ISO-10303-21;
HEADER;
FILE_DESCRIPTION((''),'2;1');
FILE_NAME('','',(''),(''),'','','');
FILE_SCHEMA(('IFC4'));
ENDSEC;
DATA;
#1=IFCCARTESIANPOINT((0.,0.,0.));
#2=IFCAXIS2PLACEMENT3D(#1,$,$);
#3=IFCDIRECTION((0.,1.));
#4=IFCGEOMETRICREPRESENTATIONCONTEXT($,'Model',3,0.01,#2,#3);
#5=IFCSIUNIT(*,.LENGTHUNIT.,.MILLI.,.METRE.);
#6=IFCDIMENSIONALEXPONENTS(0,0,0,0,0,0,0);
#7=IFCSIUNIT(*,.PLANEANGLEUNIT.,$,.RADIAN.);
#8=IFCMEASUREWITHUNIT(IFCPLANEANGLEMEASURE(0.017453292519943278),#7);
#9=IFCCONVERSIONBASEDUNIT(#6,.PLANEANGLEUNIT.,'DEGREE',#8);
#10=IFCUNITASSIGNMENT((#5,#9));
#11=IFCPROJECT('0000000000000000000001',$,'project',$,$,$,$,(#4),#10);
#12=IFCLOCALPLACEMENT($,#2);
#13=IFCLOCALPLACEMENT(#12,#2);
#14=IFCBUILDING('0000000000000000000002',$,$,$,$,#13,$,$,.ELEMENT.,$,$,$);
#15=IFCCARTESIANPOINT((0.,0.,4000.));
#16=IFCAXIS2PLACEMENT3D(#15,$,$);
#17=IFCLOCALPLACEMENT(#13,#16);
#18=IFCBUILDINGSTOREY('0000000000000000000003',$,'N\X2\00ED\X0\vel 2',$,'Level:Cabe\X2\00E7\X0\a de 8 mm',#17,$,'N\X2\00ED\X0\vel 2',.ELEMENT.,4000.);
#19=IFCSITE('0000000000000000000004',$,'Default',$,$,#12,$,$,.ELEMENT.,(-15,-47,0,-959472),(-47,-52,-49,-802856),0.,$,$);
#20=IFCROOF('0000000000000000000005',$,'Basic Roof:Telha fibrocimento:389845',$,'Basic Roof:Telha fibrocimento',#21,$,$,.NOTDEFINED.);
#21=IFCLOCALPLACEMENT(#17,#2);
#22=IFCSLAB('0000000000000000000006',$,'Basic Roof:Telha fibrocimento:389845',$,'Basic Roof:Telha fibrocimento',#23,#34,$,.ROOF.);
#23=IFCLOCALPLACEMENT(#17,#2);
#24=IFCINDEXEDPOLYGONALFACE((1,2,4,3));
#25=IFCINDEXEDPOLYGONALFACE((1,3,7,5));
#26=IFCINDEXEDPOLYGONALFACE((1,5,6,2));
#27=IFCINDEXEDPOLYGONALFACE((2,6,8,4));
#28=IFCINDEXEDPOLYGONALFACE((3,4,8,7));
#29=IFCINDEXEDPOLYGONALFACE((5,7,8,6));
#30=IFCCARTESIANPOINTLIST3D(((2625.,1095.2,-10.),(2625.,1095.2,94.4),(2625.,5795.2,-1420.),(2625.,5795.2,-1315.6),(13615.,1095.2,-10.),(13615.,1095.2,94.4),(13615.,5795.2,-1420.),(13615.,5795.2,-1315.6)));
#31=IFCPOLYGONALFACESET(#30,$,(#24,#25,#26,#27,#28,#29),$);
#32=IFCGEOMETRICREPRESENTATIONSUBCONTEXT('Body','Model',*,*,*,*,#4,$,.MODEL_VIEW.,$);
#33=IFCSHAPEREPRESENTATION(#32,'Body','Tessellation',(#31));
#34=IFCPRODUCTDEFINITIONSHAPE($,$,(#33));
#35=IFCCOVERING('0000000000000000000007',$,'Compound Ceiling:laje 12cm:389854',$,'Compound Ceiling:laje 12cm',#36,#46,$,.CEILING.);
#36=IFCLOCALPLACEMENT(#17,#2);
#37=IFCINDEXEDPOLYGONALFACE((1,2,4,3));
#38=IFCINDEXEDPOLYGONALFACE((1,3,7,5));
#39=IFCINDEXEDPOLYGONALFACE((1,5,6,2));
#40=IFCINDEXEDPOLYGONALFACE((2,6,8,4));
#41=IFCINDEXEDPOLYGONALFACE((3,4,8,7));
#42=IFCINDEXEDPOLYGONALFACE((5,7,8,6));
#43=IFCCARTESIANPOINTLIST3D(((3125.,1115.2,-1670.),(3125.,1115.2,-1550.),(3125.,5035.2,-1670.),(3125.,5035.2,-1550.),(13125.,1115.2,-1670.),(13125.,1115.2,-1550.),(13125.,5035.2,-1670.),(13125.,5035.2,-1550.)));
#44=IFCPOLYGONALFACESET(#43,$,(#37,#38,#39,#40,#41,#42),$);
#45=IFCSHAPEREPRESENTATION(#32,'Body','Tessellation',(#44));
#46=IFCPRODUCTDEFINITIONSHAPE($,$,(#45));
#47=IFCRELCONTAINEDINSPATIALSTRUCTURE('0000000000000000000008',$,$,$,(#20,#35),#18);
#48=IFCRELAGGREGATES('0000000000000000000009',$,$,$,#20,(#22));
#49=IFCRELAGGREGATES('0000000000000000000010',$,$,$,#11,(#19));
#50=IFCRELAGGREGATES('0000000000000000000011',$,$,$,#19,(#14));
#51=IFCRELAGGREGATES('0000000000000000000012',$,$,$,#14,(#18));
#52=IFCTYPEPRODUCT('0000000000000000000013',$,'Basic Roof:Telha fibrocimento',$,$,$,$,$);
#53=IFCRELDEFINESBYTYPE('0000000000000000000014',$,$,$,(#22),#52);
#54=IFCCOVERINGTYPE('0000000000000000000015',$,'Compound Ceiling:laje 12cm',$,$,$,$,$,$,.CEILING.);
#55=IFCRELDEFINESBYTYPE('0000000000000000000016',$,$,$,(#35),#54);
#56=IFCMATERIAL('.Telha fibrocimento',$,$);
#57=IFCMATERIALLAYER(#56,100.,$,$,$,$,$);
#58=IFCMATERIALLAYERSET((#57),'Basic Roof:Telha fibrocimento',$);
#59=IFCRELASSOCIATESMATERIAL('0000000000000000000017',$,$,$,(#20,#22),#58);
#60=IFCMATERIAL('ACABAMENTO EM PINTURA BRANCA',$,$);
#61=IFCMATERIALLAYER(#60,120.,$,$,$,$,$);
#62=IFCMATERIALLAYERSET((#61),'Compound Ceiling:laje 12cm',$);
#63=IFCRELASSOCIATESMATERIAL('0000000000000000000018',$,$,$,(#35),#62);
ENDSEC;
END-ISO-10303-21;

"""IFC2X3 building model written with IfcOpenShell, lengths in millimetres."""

from ifc_helpers import new_model, entity, si_unit, converted_unit, direction, frame, frame_2d, origin, place, context, subcontext, project, spatial, rectangle, extrude, material, layer, layer_set, layer_usage, type_object, element, aggregate, save


model = new_model("IFC2X3")

# Units and contexts
model_context = context("Model", 3, precision=0.01, world=origin(), true_north=direction((0.0, 1.0)))
body_context = subcontext(model_context, "Body", "Model", "MODEL_VIEW")
ifc_project = project(units=[si_unit("LENGTHUNIT", "METRE", prefix="MILLI"), converted_unit("PLANEANGLEUNIT", "DEGREE", entity("IfcPlaneAngleMeasure", 0.017453292519943278), si_unit("PLANEANGLEUNIT", "RADIAN"), dimensions=[0, 0, 0, 0, 0, 0, 0])], contexts=[model_context])

# Site, building, storey
site_placement = place(None, origin())
site = spatial("IfcSite", under=ifc_project, at=site_placement, Name="Default", CompositionType="ELEMENT", RefLatitude=(-15, -47, 0, -959472), RefLongitude=(-47, -52, -49, -802856), RefElevation=0.0)
building_placement = place(site_placement, origin())
building = spatial("IfcBuilding", under=site, at=building_placement, CompositionType="ELEMENT")
storey_placement = place(building_placement, frame((0.0, 0.0, 4000.0)))
storey = spatial("IfcBuildingStorey", under=building, at=storey_placement, Name="Nível 2", ObjectType="Level:Cabeça de 8 mm", LongName="Nível 2", CompositionType="ELEMENT", Elevation=4000.0)

# Roof, slab
ifc_material_1 = material(Name=".Telha fibrocimento")
ifc_layer_1 = layer(ifc_material_1, 100.0)
ifc_layer_set_1 = layer_set([ifc_layer_1], Name="Basic Roof:Telha fibrocimento")
roof_placement = place(storey_placement, frame((2625.0, 1095.2, -1420.0)))
roof = element("IfcRoof", 1, at=roof_placement, inside=storey, material=ifc_layer_set_1, Name="Basic Roof:Telha fibrocimento:389845", ObjectType="Basic Roof:Telha fibrocimento", ShapeType="NOTDEFINED")
type_product = type_object("IfcTypeProduct", Name="Basic Roof:Telha fibrocimento")
slab_placement = place(roof_placement, origin())
slab = element("IfcSlab", 2, at=slab_placement, type_object=type_product, material=ifc_layer_set_1, Name="Basic Roof:Telha fibrocimento:389845", ObjectType="Basic Roof:Telha fibrocimento", PredefinedType="ROOF", context=body_context, shape_type="SweptSolid", body=[
    extrude(rectangle(XDim=4906.9, YDim=10990.0, at=frame_2d((0.0, 0.0), x_axis=(0.0, 1.0))), frame((5495.0, 2350.0, 705.0), z_axis=(0.0, 0.287348, 0.957826), x_axis=(1.0, 0.0, 0.0)), (0.0, -0.287348, 0.957826), 104.4),
])
aggregate(roof, [slab])

# Covering
ifc_material_2 = material(Name="ACABAMENTO EM PINTURA BRANCA")
ifc_layer_2 = layer(ifc_material_2, 120.0)
ifc_layer_set_2 = layer_set([ifc_layer_2], Name="Compound Ceiling:laje 12cm")
ifc_layer_usage = layer_usage(ifc_layer_set_2, "AXIS3", "NEGATIVE", 120.0)
covering_type = type_object("IfcCoveringType", Name="Compound Ceiling:laje 12cm", PredefinedType="CEILING")
covering_placement = place(storey_placement, origin())
element("IfcCovering", 3, at=covering_placement, inside=storey, type_object=covering_type, material=ifc_layer_usage, Name="Compound Ceiling:laje 12cm:389854", ObjectType="Compound Ceiling:laje 12cm", PredefinedType="CEILING", context=body_context, shape_type="SweptSolid", body=[
    extrude(rectangle(XDim=10000.0, YDim=3920.0, at=frame_2d((0.0, 0.0), x_axis=(1.0, 0.0))), frame((8125.0, 3075.2, -1670.0), z_axis=(0.0, 0.0, 1.0), x_axis=(-1.0, 0.0, 0.0)), (0.0, 0.0, 1.0), 120.0),
])

save(model, "model.ifc")
